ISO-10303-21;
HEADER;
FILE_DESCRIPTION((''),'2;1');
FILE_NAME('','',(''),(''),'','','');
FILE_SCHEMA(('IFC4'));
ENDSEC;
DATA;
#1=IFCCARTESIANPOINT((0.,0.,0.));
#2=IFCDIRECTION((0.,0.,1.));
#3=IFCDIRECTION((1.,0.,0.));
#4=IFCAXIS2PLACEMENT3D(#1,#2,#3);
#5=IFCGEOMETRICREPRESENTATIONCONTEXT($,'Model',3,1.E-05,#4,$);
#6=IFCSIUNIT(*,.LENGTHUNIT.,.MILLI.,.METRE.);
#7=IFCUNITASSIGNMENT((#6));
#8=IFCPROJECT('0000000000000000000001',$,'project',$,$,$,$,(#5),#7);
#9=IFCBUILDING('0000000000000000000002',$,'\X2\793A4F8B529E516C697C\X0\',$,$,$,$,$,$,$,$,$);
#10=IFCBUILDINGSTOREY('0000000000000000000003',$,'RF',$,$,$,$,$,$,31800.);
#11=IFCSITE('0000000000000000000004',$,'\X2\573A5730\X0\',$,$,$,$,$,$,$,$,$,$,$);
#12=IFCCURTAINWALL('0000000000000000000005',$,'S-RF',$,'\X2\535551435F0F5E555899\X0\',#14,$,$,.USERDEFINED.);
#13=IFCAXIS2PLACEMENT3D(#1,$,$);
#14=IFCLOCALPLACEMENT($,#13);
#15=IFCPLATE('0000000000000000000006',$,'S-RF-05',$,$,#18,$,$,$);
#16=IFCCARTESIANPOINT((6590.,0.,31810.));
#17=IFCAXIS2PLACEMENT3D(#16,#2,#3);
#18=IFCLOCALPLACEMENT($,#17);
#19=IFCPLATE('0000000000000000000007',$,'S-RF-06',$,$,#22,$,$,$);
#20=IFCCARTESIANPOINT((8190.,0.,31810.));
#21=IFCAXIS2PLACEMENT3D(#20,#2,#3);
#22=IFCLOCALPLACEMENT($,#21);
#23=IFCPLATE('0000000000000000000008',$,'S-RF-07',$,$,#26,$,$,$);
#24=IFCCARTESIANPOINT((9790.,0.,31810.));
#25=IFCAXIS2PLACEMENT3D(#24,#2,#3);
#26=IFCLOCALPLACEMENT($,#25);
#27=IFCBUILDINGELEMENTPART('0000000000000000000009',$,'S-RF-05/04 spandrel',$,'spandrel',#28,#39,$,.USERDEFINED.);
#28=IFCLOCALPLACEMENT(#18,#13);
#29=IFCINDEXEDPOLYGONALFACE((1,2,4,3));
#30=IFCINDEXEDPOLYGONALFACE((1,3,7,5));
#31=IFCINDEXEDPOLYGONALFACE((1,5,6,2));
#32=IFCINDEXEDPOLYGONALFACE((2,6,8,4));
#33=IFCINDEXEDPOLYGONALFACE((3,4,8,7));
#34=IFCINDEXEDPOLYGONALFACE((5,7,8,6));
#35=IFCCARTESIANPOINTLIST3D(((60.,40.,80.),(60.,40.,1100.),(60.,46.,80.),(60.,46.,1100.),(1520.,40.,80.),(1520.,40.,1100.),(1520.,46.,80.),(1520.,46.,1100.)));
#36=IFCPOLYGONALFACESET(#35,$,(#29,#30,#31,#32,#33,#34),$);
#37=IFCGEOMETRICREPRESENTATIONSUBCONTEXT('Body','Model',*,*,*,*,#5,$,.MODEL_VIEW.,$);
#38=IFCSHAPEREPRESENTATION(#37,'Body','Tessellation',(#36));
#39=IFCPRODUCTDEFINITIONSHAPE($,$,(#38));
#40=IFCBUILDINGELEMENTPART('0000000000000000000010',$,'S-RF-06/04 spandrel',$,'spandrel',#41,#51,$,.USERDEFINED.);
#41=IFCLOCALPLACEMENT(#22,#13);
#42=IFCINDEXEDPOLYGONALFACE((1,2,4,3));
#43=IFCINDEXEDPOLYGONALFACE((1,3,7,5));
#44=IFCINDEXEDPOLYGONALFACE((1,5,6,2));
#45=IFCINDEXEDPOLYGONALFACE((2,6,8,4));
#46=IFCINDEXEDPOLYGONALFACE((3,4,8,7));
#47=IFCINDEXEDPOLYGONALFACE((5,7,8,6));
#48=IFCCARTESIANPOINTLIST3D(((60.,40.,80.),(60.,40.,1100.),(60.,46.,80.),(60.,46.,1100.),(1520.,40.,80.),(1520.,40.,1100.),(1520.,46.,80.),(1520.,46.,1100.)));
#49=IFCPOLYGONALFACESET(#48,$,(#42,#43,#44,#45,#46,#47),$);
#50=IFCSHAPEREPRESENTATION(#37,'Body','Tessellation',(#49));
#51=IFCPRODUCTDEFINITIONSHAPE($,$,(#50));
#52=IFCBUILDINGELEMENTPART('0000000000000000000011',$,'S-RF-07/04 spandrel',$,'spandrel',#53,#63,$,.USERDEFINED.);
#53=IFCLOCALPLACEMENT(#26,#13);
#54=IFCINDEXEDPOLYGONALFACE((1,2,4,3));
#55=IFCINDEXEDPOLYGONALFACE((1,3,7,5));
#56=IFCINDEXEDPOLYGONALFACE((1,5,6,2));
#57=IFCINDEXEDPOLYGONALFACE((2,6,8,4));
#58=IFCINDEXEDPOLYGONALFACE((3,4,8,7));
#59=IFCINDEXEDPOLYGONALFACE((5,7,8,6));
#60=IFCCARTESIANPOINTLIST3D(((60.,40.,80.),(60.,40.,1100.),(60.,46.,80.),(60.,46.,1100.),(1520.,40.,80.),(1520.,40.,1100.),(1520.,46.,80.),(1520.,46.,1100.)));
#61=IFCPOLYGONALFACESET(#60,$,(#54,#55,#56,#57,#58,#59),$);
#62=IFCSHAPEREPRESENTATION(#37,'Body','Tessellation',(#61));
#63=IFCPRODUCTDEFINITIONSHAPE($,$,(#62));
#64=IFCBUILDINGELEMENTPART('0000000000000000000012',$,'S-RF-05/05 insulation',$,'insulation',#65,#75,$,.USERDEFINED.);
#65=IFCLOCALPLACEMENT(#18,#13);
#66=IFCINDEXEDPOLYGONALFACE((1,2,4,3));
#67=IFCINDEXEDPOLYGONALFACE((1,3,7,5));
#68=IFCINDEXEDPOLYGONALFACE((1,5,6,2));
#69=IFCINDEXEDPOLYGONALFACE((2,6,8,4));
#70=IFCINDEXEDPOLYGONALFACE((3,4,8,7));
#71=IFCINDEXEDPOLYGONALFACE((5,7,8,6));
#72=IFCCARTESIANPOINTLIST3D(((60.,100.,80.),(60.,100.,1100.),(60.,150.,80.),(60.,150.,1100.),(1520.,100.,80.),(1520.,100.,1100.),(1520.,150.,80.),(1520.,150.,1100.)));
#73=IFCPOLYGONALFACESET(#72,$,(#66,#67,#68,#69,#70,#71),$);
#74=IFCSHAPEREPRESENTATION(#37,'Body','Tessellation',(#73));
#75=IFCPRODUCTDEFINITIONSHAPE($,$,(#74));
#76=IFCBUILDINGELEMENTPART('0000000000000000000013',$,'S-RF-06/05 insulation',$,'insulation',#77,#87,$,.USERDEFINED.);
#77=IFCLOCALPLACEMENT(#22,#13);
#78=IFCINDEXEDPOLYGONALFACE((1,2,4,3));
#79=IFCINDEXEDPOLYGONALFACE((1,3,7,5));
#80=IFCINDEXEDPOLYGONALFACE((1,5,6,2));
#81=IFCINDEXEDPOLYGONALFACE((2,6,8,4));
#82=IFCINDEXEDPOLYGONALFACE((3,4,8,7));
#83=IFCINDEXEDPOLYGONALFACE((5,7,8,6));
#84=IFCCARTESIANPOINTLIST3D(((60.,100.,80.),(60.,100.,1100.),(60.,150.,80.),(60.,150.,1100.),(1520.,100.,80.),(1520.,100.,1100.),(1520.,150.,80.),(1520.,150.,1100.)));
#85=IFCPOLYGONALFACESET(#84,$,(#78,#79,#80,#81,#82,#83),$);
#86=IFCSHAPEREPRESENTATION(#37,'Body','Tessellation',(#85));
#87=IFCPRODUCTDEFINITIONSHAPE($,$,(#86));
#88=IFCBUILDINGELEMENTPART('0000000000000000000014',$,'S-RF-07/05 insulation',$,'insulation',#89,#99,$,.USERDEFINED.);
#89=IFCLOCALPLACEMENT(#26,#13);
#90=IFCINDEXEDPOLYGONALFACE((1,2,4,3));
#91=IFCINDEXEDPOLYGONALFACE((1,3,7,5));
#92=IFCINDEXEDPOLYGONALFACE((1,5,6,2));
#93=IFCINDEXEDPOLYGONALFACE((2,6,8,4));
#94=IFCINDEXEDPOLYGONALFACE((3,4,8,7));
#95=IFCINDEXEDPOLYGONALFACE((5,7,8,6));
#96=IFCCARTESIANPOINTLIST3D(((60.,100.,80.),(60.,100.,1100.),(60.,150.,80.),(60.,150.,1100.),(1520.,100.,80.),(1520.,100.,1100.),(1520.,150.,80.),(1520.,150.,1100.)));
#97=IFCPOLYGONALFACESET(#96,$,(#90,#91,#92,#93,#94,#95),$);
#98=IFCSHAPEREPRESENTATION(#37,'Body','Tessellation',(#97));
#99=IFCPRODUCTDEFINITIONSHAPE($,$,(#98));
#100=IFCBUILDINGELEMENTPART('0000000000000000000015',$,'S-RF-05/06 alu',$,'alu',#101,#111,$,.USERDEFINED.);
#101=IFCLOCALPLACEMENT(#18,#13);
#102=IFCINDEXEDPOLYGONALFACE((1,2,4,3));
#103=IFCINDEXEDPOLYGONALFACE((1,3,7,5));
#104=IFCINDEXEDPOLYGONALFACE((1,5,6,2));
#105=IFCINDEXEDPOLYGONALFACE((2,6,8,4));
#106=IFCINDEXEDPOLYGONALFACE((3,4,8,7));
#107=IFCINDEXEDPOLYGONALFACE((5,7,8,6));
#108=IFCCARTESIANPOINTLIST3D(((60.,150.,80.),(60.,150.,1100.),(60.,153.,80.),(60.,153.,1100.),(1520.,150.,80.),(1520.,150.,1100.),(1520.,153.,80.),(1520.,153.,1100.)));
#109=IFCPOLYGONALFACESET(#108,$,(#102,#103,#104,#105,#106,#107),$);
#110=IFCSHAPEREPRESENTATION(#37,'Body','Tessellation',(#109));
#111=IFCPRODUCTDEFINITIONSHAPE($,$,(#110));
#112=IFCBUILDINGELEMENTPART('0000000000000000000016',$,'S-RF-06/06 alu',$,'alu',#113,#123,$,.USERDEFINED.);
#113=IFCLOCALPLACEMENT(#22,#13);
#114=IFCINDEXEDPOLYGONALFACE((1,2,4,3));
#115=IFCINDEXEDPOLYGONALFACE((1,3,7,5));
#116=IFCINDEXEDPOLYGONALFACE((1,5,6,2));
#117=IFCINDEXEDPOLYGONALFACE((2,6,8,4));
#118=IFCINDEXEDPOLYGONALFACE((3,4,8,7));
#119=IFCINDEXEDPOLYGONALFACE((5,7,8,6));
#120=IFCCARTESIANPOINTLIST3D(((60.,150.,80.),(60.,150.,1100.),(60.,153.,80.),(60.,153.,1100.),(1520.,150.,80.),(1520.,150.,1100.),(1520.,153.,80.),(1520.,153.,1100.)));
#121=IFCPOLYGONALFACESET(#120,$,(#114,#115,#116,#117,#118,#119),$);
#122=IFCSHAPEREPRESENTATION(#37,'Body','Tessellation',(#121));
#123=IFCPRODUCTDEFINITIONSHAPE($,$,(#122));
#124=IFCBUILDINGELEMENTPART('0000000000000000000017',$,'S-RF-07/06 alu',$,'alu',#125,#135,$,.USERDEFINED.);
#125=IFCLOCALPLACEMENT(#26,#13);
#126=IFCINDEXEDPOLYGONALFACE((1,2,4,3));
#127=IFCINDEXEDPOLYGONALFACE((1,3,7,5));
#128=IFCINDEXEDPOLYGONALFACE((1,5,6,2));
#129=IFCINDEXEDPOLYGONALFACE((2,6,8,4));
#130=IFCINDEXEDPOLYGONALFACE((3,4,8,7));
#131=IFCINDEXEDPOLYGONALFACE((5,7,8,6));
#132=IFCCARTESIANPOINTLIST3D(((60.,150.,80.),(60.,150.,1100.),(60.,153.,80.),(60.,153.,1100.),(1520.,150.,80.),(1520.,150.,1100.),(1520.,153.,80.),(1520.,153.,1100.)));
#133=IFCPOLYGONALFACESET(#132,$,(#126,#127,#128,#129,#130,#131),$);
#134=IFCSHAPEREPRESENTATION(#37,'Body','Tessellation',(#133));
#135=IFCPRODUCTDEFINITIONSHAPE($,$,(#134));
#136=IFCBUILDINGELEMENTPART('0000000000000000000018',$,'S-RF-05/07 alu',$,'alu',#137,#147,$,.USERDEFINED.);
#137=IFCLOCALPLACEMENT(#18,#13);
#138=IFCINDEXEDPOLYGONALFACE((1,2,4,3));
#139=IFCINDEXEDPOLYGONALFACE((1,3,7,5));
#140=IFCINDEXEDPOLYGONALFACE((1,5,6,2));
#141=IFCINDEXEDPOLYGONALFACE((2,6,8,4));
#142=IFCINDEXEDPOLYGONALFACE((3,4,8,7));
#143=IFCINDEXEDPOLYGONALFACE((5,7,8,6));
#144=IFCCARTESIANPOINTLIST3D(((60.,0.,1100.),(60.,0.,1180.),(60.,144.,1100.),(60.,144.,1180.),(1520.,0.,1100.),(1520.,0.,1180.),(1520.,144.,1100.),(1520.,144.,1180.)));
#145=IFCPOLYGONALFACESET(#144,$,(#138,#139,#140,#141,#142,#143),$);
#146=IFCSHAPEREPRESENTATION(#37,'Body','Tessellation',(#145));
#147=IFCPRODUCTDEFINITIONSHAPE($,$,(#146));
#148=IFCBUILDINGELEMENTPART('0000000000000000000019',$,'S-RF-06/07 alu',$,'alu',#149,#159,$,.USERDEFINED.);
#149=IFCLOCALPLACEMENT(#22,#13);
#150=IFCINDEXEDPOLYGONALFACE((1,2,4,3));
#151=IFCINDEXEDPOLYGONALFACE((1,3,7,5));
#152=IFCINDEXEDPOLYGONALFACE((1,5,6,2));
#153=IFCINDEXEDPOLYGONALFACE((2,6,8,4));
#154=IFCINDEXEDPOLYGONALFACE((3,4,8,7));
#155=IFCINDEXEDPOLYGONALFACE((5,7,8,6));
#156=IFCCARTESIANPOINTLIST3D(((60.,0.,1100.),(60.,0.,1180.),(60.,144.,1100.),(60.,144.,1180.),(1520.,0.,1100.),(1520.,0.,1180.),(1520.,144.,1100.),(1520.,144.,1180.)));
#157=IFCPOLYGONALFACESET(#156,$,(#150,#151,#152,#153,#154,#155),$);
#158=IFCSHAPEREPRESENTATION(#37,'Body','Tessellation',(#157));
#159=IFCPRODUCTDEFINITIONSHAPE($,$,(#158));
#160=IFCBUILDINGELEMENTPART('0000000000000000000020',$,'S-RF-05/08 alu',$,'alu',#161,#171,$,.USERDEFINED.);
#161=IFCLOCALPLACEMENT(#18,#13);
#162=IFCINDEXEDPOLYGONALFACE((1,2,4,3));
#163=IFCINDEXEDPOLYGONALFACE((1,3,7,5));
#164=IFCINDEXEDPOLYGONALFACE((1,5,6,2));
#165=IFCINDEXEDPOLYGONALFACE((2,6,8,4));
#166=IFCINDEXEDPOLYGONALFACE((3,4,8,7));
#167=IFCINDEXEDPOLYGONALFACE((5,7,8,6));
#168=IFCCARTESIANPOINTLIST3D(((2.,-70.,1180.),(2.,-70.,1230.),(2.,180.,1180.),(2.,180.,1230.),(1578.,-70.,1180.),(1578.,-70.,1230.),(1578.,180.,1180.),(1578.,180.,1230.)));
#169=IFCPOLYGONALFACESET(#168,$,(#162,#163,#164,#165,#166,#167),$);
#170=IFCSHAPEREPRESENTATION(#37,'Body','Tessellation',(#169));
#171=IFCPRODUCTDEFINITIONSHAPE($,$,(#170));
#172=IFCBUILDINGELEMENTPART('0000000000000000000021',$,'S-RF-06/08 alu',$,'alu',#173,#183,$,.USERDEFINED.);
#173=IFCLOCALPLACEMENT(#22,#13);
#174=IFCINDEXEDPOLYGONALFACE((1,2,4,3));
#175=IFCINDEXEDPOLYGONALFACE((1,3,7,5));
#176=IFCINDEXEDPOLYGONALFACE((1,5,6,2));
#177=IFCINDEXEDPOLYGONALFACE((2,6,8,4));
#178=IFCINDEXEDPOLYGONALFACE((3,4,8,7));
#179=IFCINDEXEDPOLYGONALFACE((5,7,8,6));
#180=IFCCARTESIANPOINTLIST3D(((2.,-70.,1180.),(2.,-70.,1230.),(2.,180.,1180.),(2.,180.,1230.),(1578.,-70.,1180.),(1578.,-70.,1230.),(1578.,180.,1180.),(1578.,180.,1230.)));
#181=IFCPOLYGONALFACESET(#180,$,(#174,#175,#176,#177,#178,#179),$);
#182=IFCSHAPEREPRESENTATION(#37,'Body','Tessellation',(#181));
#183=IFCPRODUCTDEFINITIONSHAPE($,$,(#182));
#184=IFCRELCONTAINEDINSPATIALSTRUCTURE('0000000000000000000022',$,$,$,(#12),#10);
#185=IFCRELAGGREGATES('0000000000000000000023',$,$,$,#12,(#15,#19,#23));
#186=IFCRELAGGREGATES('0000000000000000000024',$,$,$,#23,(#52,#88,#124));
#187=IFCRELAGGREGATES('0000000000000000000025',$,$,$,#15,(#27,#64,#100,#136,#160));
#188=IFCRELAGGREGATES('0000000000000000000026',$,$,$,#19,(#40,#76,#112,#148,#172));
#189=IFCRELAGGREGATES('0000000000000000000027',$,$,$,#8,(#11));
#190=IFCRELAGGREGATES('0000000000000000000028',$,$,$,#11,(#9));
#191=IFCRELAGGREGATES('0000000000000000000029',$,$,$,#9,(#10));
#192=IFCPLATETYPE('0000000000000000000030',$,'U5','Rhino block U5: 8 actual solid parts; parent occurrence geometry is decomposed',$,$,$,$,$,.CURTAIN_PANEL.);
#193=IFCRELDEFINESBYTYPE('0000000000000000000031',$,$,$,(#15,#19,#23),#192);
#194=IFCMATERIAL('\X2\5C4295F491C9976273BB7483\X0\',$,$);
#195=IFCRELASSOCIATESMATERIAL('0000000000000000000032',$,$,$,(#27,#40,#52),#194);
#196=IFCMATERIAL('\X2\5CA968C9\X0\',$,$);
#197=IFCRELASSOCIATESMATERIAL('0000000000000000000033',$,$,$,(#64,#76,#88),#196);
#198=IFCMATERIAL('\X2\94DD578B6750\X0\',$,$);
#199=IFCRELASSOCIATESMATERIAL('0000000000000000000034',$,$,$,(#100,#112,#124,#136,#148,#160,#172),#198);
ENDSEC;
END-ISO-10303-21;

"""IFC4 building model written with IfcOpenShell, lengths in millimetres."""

from ifc_helpers import new_model, si_unit, frame, frame_2d, origin, origin_with_axes, place, context, subcontext, project, spatial, rectangle, extrude, source, transform, mapped, material, type_object, element, aggregate, save


model = new_model("IFC4")

# Units and contexts
model_context = context("Model", 3, precision=1e-05, world=origin_with_axes())
body_context = subcontext(model_context, "Body", "Model", "MODEL_VIEW")
ifc_project = project(units=[si_unit("LENGTHUNIT", "METRE", prefix="MILLI")], contexts=[model_context])

# Site, building, storey
site = spatial("IfcSite", under=ifc_project, Name="场地")
building = spatial("IfcBuilding", under=site, Name="示例办公楼")
storey = spatial("IfcBuildingStorey", under=building, Name="RF", Elevation=31800.0)

# Curtain wall, plates, building element parts
curtain_wall = element("IfcCurtainWall", 1, inside=storey, Name="S-RF", ObjectType="单元式幕墙", PredefinedType="USERDEFINED")
plate_type = type_object("IfcPlateType", Name="U5", Description="Rhino block U5: 8 actual solid parts; parent occurrence geometry is decomposed", PredefinedType="CURTAIN_PANEL")
plate_1_placement = place(None, frame((6590.0, 0.0, 31810.0), z_axis=(0.0, 0.0, 1.0), x_axis=(1.0, 0.0, 0.0)))
plate_1 = element("IfcPlate", 2, at=plate_1_placement, type_object=plate_type, Name="S-RF-05")
ifc_material_1 = material(Name="铝型材")
plate_2_placement = place(None, frame((8190.0, 0.0, 31810.0), z_axis=(0.0, 0.0, 1.0), x_axis=(1.0, 0.0, 0.0)))
plate_2 = element("IfcPlate", 3, at=plate_2_placement, type_object=plate_type, Name="S-RF-06")
plate_3_placement = place(None, frame((9790.0, 0.0, 31810.0), z_axis=(0.0, 0.0, 1.0), x_axis=(1.0, 0.0, 0.0)))
plate_3 = element("IfcPlate", 4, at=plate_3_placement, type_object=plate_type, Name="S-RF-07")
aggregate(curtain_wall, [plate_1, plate_2, plate_3])
ifc_material_2 = material(Name="层间釉面玻璃")
shared_shape_1 = source(origin(), body_context, "Body", "SweptSolid", [
    extrude(rectangle(XDim=1460.0, YDim=6.0, at=frame_2d((790.0, 43.0))), frame((0.0, 0.0, 80.0)), (0.0, 0.0, 1.0), 1020.0),
])
building_element_part_1_placement = place(plate_1_placement, origin())
building_element_part_1 = element("IfcBuildingElementPart", 5, at=building_element_part_1_placement, material=ifc_material_2, Name="S-RF-05/04 spandrel", ObjectType="spandrel", PredefinedType="USERDEFINED", context=body_context, shape_type="MappedRepresentation", body=[
    mapped(shared_shape_1, transform((0.0, 0.0, 0.0))),
])
building_element_part_2_placement = place(plate_2_placement, origin())
building_element_part_2 = element("IfcBuildingElementPart", 6, at=building_element_part_2_placement, material=ifc_material_2, Name="S-RF-06/04 spandrel", ObjectType="spandrel", PredefinedType="USERDEFINED", context=body_context, shape_type="MappedRepresentation", body=[
    mapped(shared_shape_1, transform((0.0, 0.0, 0.0))),
])
building_element_part_3_placement = place(plate_3_placement, origin())
building_element_part_3 = element("IfcBuildingElementPart", 7, at=building_element_part_3_placement, material=ifc_material_2, Name="S-RF-07/04 spandrel", ObjectType="spandrel", PredefinedType="USERDEFINED", context=body_context, shape_type="MappedRepresentation", body=[
    mapped(shared_shape_1, transform((0.0, 0.0, 0.0))),
])
ifc_material_3 = material(Name="岩棉")
shared_shape_2 = source(origin(), body_context, "Body", "SweptSolid", [
    extrude(rectangle(XDim=1460.0, YDim=50.0, at=frame_2d((790.0, 125.0))), frame((0.0, 0.0, 80.0)), (0.0, 0.0, 1.0), 1020.0),
])
building_element_part_4_placement = place(plate_1_placement, origin())
building_element_part_4 = element("IfcBuildingElementPart", 8, at=building_element_part_4_placement, material=ifc_material_3, Name="S-RF-05/05 insulation", ObjectType="insulation", PredefinedType="USERDEFINED", context=body_context, shape_type="MappedRepresentation", body=[
    mapped(shared_shape_2, transform((0.0, 0.0, 0.0))),
])
building_element_part_5_placement = place(plate_2_placement, origin())
building_element_part_5 = element("IfcBuildingElementPart", 9, at=building_element_part_5_placement, material=ifc_material_3, Name="S-RF-06/05 insulation", ObjectType="insulation", PredefinedType="USERDEFINED", context=body_context, shape_type="MappedRepresentation", body=[
    mapped(shared_shape_2, transform((0.0, 0.0, 0.0))),
])
building_element_part_6_placement = place(plate_3_placement, origin())
building_element_part_6 = element("IfcBuildingElementPart", 10, at=building_element_part_6_placement, material=ifc_material_3, Name="S-RF-07/05 insulation", ObjectType="insulation", PredefinedType="USERDEFINED", context=body_context, shape_type="MappedRepresentation", body=[
    mapped(shared_shape_2, transform((0.0, 0.0, 0.0))),
])
shared_shape_3 = source(origin(), body_context, "Body", "SweptSolid", [
    extrude(rectangle(XDim=1460.0, YDim=3.0, at=frame_2d((790.0, 151.5))), frame((0.0, 0.0, 80.0)), (0.0, 0.0, 1.0), 1020.0),
])
building_element_part_7_placement = place(plate_1_placement, origin())
building_element_part_7 = element("IfcBuildingElementPart", 11, at=building_element_part_7_placement, material=ifc_material_1, Name="S-RF-05/06 alu", ObjectType="alu", PredefinedType="USERDEFINED", context=body_context, shape_type="MappedRepresentation", body=[
    mapped(shared_shape_3, transform((0.0, 0.0, 0.0))),
])
building_element_part_8_placement = place(plate_2_placement, origin())
building_element_part_8 = element("IfcBuildingElementPart", 12, at=building_element_part_8_placement, material=ifc_material_1, Name="S-RF-06/06 alu", ObjectType="alu", PredefinedType="USERDEFINED", context=body_context, shape_type="MappedRepresentation", body=[
    mapped(shared_shape_3, transform((0.0, 0.0, 0.0))),
])
building_element_part_9_placement = place(plate_3_placement, origin())
building_element_part_9 = element("IfcBuildingElementPart", 13, at=building_element_part_9_placement, material=ifc_material_1, Name="S-RF-07/06 alu", ObjectType="alu", PredefinedType="USERDEFINED", context=body_context, shape_type="MappedRepresentation", body=[
    mapped(shared_shape_3, transform((0.0, 0.0, 0.0))),
])
aggregate(plate_3, [building_element_part_3, building_element_part_6, building_element_part_9])
shared_shape_4 = source(origin(), body_context, "Body", "SweptSolid", [
    extrude(rectangle(XDim=1460.0, YDim=144.0, at=frame_2d((790.0, 72.0))), frame((0.0, 0.0, 1100.0)), (0.0, 0.0, 1.0), 80.0),
])
building_element_part_10_placement = place(plate_1_placement, origin())
building_element_part_10 = element("IfcBuildingElementPart", 14, at=building_element_part_10_placement, material=ifc_material_1, Name="S-RF-05/07 alu", ObjectType="alu", PredefinedType="USERDEFINED", context=body_context, shape_type="MappedRepresentation", body=[
    mapped(shared_shape_4, transform((0.0, 0.0, 0.0))),
])
building_element_part_11_placement = place(plate_2_placement, origin())
building_element_part_11 = element("IfcBuildingElementPart", 15, at=building_element_part_11_placement, material=ifc_material_1, Name="S-RF-06/07 alu", ObjectType="alu", PredefinedType="USERDEFINED", context=body_context, shape_type="MappedRepresentation", body=[
    mapped(shared_shape_4, transform((0.0, 0.0, 0.0))),
])
shared_shape_5 = source(origin(), body_context, "Body", "SweptSolid", [
    extrude(rectangle(XDim=1576.0, YDim=250.0, at=frame_2d((790.0, 55.0))), frame((0.0, 0.0, 1180.0)), (0.0, 0.0, 1.0), 50.0),
])
building_element_part_12_placement = place(plate_1_placement, origin())
building_element_part_12 = element("IfcBuildingElementPart", 16, at=building_element_part_12_placement, material=ifc_material_1, Name="S-RF-05/08 alu", ObjectType="alu", PredefinedType="USERDEFINED", context=body_context, shape_type="MappedRepresentation", body=[
    mapped(shared_shape_5, transform((0.0, 0.0, 0.0))),
])
aggregate(plate_1, [building_element_part_1, building_element_part_4, building_element_part_7, building_element_part_10, building_element_part_12])
building_element_part_13_placement = place(plate_2_placement, origin())
building_element_part_13 = element("IfcBuildingElementPart", 17, at=building_element_part_13_placement, material=ifc_material_1, Name="S-RF-06/08 alu", ObjectType="alu", PredefinedType="USERDEFINED", context=body_context, shape_type="MappedRepresentation", body=[
    mapped(shared_shape_5, transform((0.0, 0.0, 0.0))),
])
aggregate(plate_2, [building_element_part_2, building_element_part_5, building_element_part_8, building_element_part_11, building_element_part_13])

save(model, "model.ifc")
